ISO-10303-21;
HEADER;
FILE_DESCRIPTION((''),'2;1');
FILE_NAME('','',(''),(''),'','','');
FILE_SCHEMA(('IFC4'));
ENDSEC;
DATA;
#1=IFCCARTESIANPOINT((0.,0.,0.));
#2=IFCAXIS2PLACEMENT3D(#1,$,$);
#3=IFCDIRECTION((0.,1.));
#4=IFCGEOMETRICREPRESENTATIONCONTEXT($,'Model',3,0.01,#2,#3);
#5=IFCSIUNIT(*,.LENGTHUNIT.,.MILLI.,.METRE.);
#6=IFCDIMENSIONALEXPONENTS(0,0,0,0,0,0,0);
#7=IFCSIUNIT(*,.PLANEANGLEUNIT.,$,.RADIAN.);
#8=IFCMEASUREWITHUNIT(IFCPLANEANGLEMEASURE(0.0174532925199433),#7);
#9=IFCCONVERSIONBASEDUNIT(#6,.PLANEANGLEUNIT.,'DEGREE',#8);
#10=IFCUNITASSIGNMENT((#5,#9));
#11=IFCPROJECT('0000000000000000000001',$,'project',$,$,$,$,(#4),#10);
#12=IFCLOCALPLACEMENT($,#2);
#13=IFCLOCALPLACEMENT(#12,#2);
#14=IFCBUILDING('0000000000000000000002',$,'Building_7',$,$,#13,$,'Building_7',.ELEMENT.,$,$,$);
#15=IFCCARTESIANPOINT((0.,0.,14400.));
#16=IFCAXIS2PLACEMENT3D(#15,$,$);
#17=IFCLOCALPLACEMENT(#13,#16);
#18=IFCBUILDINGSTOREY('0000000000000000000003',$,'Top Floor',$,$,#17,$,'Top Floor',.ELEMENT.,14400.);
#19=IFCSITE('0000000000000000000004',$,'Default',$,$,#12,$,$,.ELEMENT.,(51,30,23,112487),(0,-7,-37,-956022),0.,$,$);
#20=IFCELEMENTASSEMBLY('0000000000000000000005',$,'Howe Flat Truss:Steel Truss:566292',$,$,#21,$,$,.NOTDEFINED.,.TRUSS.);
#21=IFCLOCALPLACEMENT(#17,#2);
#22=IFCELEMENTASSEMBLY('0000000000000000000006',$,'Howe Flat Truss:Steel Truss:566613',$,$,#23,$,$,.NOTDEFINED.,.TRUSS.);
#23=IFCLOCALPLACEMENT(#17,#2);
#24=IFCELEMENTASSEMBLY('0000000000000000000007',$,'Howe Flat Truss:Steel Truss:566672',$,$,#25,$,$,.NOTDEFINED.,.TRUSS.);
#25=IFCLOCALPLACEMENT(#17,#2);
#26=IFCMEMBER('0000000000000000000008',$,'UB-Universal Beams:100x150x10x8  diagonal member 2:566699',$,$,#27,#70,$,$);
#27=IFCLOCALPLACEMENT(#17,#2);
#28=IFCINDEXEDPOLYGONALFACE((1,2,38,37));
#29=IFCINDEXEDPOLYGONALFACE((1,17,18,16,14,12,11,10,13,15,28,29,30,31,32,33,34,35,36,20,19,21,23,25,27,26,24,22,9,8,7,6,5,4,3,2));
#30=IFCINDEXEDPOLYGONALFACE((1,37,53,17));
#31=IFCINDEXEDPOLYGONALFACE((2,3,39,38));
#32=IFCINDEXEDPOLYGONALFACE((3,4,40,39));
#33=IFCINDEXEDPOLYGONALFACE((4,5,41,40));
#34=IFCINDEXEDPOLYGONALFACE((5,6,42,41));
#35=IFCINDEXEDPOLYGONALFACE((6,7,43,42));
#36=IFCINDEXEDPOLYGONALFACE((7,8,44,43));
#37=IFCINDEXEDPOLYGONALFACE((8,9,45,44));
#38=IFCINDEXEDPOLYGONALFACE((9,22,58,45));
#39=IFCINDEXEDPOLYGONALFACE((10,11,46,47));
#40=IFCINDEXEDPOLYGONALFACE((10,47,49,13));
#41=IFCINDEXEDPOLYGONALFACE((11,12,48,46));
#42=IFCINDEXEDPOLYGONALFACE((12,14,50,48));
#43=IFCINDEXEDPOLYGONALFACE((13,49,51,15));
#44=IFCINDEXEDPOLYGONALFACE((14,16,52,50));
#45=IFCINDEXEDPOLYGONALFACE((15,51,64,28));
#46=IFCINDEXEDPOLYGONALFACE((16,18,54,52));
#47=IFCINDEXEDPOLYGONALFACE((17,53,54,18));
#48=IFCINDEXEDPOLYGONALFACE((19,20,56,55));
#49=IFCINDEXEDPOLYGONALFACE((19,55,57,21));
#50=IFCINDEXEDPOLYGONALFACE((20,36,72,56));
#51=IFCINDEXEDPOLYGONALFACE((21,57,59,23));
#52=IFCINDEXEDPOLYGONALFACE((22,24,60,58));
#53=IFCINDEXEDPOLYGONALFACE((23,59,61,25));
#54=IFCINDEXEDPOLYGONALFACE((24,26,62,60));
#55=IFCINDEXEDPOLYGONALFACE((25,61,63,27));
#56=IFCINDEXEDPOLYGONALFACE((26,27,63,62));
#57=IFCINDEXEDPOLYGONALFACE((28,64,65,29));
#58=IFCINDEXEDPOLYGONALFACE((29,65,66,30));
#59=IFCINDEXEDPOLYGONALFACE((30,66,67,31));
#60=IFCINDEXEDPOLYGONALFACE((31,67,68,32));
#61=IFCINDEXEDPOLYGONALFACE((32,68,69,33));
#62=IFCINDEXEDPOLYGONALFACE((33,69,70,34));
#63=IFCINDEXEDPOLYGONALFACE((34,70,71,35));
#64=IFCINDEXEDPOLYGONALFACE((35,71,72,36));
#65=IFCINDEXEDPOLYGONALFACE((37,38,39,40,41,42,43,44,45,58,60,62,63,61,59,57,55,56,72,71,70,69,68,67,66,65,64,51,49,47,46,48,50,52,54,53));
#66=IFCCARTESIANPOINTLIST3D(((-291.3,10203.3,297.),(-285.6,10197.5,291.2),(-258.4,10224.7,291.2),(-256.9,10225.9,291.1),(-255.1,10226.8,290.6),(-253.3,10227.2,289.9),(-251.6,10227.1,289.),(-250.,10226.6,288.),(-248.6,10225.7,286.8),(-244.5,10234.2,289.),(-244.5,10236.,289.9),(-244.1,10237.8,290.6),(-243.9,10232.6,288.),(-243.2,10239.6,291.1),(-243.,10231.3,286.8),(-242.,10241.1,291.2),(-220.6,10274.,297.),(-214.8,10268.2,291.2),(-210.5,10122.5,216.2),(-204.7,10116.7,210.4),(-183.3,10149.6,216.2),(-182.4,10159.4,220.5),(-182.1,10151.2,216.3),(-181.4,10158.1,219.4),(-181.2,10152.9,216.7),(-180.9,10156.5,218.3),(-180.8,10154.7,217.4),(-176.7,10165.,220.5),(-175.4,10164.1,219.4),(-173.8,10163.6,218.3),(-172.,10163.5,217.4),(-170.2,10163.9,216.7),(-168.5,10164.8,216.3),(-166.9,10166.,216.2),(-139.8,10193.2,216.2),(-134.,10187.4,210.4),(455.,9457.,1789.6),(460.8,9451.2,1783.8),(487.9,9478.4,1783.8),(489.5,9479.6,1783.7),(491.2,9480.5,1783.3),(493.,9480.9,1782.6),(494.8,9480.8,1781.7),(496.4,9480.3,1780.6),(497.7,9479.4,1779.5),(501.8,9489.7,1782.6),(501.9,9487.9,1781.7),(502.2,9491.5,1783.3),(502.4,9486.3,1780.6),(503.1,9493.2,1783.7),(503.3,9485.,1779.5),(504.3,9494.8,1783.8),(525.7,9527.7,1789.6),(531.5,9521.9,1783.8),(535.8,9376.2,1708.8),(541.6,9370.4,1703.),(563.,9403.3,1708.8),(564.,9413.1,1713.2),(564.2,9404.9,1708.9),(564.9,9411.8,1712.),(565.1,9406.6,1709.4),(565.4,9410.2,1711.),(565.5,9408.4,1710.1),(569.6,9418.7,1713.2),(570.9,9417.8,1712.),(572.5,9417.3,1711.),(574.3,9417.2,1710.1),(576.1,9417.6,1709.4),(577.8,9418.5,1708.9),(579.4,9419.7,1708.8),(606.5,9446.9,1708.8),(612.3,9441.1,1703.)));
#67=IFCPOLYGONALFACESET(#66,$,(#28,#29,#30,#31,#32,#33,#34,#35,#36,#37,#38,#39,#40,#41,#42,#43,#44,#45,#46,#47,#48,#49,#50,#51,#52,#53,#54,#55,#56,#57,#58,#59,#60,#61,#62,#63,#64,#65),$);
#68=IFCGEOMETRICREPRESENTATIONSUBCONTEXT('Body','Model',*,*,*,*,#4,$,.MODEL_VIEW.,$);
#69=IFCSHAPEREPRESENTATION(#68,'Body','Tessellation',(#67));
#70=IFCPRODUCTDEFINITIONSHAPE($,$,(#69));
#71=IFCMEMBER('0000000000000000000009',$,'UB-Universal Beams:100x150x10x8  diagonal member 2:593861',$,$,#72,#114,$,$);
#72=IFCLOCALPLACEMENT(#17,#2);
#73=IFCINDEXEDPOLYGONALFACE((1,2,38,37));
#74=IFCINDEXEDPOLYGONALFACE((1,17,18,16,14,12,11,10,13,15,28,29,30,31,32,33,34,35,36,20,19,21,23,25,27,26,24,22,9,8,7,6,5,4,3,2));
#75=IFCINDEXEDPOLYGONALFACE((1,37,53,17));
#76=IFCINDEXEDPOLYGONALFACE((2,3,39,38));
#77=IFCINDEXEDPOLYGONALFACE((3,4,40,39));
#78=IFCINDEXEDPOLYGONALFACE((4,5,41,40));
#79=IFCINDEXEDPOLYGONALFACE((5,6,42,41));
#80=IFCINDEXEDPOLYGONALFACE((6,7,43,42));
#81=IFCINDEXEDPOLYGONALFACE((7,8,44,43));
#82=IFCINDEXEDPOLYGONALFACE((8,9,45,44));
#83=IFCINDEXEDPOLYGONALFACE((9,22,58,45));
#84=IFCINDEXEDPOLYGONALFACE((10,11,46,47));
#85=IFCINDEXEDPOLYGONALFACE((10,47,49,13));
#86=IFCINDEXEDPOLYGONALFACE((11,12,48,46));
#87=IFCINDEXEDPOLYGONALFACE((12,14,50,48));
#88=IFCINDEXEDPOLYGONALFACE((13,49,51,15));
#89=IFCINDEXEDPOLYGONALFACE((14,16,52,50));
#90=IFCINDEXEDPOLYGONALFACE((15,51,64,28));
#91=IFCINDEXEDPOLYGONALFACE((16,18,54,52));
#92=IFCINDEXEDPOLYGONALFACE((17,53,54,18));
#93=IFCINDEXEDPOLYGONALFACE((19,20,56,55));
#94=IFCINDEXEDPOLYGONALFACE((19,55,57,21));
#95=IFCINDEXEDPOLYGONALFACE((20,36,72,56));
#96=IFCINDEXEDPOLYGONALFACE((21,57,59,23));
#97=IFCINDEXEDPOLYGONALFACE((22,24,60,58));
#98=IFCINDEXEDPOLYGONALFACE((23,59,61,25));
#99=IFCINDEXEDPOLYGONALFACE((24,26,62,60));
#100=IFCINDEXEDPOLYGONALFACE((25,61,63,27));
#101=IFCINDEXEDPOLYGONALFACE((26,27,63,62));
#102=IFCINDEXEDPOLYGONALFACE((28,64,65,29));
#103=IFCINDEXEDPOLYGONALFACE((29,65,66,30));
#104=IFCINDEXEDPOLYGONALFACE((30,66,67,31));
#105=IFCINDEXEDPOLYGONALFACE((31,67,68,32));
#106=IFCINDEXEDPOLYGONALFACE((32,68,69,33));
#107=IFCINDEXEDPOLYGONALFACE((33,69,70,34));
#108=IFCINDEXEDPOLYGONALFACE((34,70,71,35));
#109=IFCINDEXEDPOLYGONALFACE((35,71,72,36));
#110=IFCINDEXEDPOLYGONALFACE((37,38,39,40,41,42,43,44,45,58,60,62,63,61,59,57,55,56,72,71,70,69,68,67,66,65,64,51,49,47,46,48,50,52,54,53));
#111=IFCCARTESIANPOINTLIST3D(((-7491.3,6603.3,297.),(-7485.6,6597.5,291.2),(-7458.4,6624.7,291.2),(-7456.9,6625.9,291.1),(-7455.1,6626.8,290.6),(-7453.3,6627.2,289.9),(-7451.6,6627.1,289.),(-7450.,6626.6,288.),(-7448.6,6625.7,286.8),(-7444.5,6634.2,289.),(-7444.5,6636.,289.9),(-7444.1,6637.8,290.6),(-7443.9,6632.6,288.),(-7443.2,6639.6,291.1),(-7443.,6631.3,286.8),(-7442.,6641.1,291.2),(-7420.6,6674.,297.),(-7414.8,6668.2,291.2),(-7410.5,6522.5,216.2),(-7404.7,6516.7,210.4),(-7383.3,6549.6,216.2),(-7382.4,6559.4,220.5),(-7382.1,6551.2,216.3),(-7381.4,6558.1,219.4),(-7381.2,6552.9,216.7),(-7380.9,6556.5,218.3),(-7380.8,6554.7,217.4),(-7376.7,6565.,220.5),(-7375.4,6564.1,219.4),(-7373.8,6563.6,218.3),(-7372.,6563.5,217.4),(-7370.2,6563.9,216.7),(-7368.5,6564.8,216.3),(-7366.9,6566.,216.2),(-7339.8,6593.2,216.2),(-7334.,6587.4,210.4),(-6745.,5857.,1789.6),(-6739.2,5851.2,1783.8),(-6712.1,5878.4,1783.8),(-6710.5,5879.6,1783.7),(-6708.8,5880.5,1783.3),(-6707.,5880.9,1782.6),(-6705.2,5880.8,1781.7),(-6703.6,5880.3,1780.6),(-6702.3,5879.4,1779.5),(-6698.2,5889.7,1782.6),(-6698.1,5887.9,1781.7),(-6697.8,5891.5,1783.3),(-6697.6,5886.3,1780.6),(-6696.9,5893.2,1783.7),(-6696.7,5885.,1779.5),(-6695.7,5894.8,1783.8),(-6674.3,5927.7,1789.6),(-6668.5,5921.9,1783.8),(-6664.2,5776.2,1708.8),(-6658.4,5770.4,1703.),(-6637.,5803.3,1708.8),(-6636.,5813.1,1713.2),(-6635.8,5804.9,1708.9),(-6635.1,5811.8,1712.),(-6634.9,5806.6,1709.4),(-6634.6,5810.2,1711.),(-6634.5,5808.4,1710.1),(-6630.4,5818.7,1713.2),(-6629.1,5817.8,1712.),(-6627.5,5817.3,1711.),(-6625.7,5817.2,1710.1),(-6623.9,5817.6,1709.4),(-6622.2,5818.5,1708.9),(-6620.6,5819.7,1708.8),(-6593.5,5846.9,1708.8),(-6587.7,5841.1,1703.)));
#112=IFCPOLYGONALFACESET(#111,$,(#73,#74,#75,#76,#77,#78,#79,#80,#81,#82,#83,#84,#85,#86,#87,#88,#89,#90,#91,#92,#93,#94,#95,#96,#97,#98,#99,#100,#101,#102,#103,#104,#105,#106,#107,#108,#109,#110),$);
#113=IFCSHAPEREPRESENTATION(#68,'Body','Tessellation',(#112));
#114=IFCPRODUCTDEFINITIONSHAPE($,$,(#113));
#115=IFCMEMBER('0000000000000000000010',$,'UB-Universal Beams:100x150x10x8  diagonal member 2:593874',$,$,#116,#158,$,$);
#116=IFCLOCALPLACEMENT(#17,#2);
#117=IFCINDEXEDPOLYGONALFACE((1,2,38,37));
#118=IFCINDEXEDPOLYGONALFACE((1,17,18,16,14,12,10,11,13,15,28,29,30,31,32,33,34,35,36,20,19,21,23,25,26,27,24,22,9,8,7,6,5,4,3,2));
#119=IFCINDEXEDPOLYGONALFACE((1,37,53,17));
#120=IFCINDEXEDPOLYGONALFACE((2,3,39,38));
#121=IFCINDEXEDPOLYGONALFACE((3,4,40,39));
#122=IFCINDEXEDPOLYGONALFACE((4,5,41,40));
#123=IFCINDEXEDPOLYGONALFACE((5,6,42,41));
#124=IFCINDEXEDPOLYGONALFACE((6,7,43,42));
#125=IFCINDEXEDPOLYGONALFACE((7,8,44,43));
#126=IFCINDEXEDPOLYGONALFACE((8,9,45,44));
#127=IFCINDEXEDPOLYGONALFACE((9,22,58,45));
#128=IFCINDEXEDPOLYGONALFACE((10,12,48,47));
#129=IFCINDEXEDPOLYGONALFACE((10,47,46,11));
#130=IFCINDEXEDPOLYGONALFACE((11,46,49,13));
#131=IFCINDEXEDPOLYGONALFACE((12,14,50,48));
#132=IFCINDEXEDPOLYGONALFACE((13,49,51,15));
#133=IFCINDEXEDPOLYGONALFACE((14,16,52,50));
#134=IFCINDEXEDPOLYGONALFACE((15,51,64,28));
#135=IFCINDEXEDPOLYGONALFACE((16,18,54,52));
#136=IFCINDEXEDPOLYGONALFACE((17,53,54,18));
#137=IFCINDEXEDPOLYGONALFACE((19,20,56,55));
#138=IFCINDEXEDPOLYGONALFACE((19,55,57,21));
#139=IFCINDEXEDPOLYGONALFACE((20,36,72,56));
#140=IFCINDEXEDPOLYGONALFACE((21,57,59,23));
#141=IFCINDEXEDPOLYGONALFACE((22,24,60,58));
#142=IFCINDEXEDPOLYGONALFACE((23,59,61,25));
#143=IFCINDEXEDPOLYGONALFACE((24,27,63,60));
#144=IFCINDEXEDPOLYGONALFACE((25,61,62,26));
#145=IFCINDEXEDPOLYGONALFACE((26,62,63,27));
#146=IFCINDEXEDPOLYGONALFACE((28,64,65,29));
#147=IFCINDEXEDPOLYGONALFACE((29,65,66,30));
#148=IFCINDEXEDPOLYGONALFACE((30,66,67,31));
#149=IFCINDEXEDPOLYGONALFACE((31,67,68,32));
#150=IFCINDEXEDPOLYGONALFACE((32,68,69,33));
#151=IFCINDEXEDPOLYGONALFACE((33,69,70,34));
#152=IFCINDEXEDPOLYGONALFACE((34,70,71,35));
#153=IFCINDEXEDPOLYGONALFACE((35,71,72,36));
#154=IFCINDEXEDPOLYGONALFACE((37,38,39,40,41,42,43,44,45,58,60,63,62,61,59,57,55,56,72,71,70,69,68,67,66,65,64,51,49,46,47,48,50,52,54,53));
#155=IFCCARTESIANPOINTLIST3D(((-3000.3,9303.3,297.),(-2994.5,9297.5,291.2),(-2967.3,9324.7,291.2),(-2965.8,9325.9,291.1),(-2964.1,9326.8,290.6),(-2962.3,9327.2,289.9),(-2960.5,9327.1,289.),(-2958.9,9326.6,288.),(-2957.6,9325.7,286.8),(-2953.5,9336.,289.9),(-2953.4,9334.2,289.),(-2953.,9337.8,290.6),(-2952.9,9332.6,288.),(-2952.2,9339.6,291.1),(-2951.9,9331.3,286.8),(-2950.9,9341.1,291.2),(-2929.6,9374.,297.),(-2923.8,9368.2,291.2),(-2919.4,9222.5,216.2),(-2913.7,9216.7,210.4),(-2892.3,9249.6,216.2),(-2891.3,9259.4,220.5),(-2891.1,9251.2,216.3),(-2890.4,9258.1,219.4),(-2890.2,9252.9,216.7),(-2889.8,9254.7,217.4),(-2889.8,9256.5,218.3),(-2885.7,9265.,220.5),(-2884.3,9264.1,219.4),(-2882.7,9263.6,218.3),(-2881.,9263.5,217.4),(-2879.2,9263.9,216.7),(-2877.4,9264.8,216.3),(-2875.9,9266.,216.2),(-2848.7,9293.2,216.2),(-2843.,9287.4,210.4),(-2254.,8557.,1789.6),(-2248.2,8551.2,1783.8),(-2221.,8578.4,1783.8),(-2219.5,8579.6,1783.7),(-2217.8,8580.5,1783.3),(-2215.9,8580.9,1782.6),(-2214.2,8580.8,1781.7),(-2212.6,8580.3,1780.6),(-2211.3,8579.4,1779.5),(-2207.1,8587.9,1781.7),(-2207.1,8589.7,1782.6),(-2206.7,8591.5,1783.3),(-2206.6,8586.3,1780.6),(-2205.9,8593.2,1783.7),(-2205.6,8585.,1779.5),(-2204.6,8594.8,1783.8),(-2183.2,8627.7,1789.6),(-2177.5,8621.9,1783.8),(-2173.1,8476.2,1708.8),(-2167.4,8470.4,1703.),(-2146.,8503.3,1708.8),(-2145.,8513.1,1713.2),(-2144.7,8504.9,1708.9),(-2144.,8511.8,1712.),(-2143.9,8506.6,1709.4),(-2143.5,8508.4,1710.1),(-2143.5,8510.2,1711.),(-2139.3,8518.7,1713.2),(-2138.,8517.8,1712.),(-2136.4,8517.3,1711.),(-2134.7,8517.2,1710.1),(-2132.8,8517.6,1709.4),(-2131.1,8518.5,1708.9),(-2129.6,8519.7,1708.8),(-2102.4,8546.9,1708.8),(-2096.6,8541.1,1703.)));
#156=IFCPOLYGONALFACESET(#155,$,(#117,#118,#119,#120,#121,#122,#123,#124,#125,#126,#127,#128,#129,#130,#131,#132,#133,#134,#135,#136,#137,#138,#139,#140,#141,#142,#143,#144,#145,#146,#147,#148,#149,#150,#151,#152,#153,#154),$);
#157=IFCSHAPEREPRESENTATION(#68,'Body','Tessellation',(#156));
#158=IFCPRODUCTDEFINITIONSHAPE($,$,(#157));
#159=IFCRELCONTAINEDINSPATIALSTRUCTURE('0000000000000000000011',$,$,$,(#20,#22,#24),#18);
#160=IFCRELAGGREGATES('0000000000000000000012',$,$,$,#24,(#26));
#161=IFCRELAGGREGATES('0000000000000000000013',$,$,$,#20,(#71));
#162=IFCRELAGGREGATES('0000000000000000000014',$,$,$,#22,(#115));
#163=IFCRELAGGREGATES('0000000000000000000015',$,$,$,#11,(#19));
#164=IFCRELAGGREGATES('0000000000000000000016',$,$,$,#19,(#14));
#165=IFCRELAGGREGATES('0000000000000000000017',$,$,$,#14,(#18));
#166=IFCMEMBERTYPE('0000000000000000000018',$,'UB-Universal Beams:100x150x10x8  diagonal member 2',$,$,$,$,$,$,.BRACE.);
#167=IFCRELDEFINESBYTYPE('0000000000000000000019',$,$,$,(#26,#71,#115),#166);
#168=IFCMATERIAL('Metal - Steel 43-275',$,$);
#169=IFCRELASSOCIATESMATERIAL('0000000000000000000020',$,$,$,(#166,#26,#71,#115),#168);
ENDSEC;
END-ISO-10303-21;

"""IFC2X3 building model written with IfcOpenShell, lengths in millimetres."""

from ifc_helpers import new_model, entity, si_unit, converted_unit, direction, frame, frame_2d, origin, place, context, subcontext, project, spatial, polyline, circle_curve, parameter, trimmed, segment, composite_curve, outline, extrude, source, transform, mapped, material, type_object, type_shapes, element, aggregate, save


model = new_model("IFC2X3")

# Units and contexts
model_context = context("Model", 3, precision=0.01, world=origin(), true_north=direction((0.0, 1.0)))
body_context = subcontext(model_context, "Body", "Model", "MODEL_VIEW")
ifc_project = project(units=[si_unit("LENGTHUNIT", "METRE", prefix="MILLI"), converted_unit("PLANEANGLEUNIT", "DEGREE", entity("IfcPlaneAngleMeasure", 0.0174532925199433), si_unit("PLANEANGLEUNIT", "RADIAN"), dimensions=[0, 0, 0, 0, 0, 0, 0])], contexts=[model_context])

# Site, building, storey
site_placement = place(None, origin())
site = spatial("IfcSite", under=ifc_project, at=site_placement, Name="Default", CompositionType="ELEMENT", RefLatitude=(51, 30, 23, 112487), RefLongitude=(0, -7, -37, -956022), RefElevation=0.0)
building_placement = place(site_placement, origin())
building = spatial("IfcBuilding", under=site, at=building_placement, Name="Building_7", LongName="Building_7", CompositionType="ELEMENT")
storey_placement = place(building_placement, frame((0.0, 0.0, 14400.0)))
storey = spatial("IfcBuildingStorey", under=building, at=storey_placement, Name="Top Floor", LongName="Top Floor", CompositionType="ELEMENT", Elevation=14400.0)

# Shared definitions
ifc_material = material(Name="Metal - Steel 43-275")

# Element assembly
assembly_1_placement = place(storey_placement, origin())
assembly_1 = element("IfcElementAssembly", 1, at=assembly_1_placement, inside=storey, Name="Howe Flat Truss:Steel Truss:566292", AssemblyPlace="NOTDEFINED", PredefinedType="TRUSS")

# Element assemblies
assembly_2_placement = place(storey_placement, origin())
assembly_2 = element("IfcElementAssembly", 2, at=assembly_2_placement, inside=storey, Name="Howe Flat Truss:Steel Truss:566613", AssemblyPlace="NOTDEFINED", PredefinedType="TRUSS")
assembly_3_placement = place(storey_placement, origin())
assembly_3 = element("IfcElementAssembly", 3, at=assembly_3_placement, inside=storey, Name="Howe Flat Truss:Steel Truss:566672", AssemblyPlace="NOTDEFINED", PredefinedType="TRUSS")

# Members
member_type_1 = type_object("IfcMemberType", Name="UB-Universal Beams:100x150x10x8  diagonal member 2", PredefinedType="BRACE", material=ifc_material)
shared_shape_1 = source(origin(), body_context, "Body", "SweptSolid", [
    extrude(outline(composite_curve([segment(polyline([(-50.0, -65.0), (-50.0, -75.0)]), True, "CONTINUOUS"), segment(polyline([(-50.0, -75.0), (50.0, -75.0)]), True, "CONTINUOUS"), segment(polyline([(50.0, -75.0), (50.0, -65.0)]), True, "CONTINUOUS"), segment(polyline([(50.0, -65.0), (11.6, -65.0)]), True, "CONTINUOUS"), segment(trimmed(circle_curve(frame_2d((11.6, -57.4), x_axis=(1.0, 0.0)), 7.6), [parameter(180.0)], [parameter(270.0)], True, "PARAMETER"), False, "CONTINUOUS"), segment(polyline([(4.0, -57.4), (4.0, 57.4)]), True, "CONTINUOUS"), segment(trimmed(circle_curve(frame_2d((11.6, 57.4), x_axis=(1.0, 0.0)), 7.6), [parameter(90.0)], [parameter(180.0)], True, "PARAMETER"), False, "CONTINUOUS"), segment(polyline([(11.6, 65.0), (50.0, 65.0)]), True, "CONTINUOUS"), segment(polyline([(50.0, 65.0), (50.0, 75.0)]), True, "CONTINUOUS"), segment(polyline([(50.0, 75.0), (-50.0, 75.0)]), True, "CONTINUOUS"), segment(polyline([(-50.0, 75.0), (-50.0, 65.0)]), True, "CONTINUOUS"), segment(polyline([(-50.0, 65.0), (-11.6, 65.0)]), True, "CONTINUOUS"), segment(trimmed(circle_curve(frame_2d((-11.6, 57.4), x_axis=(1.0, 0.0)), 7.6), [parameter(360.0)], [parameter(90.0)], True, "PARAMETER"), False, "CONTINUOUS"), segment(polyline([(-4.0, 57.4), (-4.0, -57.4)]), True, "CONTINUOUS"), segment(trimmed(circle_curve(frame_2d((-11.6, -57.4), x_axis=(1.0, 0.0)), 7.6), [parameter(270.0)], [parameter(360.0)], True, "PARAMETER"), False, "CONTINUOUS"), segment(polyline([(-11.6, -65.0), (-50.0, -65.0)]), True, "CONTINUOUS")], self_intersect=False)), frame((-914.0, 0.0, 0.0), z_axis=(-1.0, 0.0, 0.0), x_axis=(0.0, -1.0, 0.0)), (0.0, 0.0, -1.0), 1828.1),
])
type_shapes(member_type_1, [shared_shape_1])
member_1_placement = place(assembly_3_placement, frame((160.5, 9822.2, 1000.0), z_axis=(0.57735, -0.57735, -0.57735), x_axis=(-0.408248, 0.408248, -0.816497)))
member_1 = element("IfcMember", 4, at=member_1_placement, type_object=member_type_1, material=ifc_material, Name="UB-Universal Beams:100x150x10x8  diagonal member 2:566699", context=body_context, shape_type="MappedRepresentation", body=[
    mapped(shared_shape_1, transform((0.0, 0.0, 0.0), scale=1.0)),
])
aggregate(assembly_3, [member_1])
member_2_placement = place(assembly_1_placement, frame((-7039.5, 6222.2, 1000.0), z_axis=(0.57735, -0.57735, -0.57735), x_axis=(-0.408248, 0.408248, -0.816497)))
member_2 = element("IfcMember", 5, at=member_2_placement, type_object=member_type_1, material=ifc_material, Name="UB-Universal Beams:100x150x10x8  diagonal member 2:593861", context=body_context, shape_type="MappedRepresentation", body=[
    mapped(shared_shape_1, transform((0.0, 0.0, 0.0), scale=1.0)),
])
aggregate(assembly_1, [member_2])
member_3_placement = place(assembly_2_placement, frame((-2548.5, 8922.2, 1000.0), z_axis=(0.57735, -0.57735, -0.57735), x_axis=(0.408248, -0.408248, 0.816497)))
member_3 = element("IfcMember", 6, at=member_3_placement, type_object=member_type_1, material=ifc_material, Name="UB-Universal Beams:100x150x10x8  diagonal member 2:593874", context=body_context, shape_type="MappedRepresentation", body=[
    mapped(shared_shape_1, transform((0.0, 0.0, 0.0), scale=1.0)),
])
aggregate(assembly_2, [member_3])

save(model, "model.ifc")
